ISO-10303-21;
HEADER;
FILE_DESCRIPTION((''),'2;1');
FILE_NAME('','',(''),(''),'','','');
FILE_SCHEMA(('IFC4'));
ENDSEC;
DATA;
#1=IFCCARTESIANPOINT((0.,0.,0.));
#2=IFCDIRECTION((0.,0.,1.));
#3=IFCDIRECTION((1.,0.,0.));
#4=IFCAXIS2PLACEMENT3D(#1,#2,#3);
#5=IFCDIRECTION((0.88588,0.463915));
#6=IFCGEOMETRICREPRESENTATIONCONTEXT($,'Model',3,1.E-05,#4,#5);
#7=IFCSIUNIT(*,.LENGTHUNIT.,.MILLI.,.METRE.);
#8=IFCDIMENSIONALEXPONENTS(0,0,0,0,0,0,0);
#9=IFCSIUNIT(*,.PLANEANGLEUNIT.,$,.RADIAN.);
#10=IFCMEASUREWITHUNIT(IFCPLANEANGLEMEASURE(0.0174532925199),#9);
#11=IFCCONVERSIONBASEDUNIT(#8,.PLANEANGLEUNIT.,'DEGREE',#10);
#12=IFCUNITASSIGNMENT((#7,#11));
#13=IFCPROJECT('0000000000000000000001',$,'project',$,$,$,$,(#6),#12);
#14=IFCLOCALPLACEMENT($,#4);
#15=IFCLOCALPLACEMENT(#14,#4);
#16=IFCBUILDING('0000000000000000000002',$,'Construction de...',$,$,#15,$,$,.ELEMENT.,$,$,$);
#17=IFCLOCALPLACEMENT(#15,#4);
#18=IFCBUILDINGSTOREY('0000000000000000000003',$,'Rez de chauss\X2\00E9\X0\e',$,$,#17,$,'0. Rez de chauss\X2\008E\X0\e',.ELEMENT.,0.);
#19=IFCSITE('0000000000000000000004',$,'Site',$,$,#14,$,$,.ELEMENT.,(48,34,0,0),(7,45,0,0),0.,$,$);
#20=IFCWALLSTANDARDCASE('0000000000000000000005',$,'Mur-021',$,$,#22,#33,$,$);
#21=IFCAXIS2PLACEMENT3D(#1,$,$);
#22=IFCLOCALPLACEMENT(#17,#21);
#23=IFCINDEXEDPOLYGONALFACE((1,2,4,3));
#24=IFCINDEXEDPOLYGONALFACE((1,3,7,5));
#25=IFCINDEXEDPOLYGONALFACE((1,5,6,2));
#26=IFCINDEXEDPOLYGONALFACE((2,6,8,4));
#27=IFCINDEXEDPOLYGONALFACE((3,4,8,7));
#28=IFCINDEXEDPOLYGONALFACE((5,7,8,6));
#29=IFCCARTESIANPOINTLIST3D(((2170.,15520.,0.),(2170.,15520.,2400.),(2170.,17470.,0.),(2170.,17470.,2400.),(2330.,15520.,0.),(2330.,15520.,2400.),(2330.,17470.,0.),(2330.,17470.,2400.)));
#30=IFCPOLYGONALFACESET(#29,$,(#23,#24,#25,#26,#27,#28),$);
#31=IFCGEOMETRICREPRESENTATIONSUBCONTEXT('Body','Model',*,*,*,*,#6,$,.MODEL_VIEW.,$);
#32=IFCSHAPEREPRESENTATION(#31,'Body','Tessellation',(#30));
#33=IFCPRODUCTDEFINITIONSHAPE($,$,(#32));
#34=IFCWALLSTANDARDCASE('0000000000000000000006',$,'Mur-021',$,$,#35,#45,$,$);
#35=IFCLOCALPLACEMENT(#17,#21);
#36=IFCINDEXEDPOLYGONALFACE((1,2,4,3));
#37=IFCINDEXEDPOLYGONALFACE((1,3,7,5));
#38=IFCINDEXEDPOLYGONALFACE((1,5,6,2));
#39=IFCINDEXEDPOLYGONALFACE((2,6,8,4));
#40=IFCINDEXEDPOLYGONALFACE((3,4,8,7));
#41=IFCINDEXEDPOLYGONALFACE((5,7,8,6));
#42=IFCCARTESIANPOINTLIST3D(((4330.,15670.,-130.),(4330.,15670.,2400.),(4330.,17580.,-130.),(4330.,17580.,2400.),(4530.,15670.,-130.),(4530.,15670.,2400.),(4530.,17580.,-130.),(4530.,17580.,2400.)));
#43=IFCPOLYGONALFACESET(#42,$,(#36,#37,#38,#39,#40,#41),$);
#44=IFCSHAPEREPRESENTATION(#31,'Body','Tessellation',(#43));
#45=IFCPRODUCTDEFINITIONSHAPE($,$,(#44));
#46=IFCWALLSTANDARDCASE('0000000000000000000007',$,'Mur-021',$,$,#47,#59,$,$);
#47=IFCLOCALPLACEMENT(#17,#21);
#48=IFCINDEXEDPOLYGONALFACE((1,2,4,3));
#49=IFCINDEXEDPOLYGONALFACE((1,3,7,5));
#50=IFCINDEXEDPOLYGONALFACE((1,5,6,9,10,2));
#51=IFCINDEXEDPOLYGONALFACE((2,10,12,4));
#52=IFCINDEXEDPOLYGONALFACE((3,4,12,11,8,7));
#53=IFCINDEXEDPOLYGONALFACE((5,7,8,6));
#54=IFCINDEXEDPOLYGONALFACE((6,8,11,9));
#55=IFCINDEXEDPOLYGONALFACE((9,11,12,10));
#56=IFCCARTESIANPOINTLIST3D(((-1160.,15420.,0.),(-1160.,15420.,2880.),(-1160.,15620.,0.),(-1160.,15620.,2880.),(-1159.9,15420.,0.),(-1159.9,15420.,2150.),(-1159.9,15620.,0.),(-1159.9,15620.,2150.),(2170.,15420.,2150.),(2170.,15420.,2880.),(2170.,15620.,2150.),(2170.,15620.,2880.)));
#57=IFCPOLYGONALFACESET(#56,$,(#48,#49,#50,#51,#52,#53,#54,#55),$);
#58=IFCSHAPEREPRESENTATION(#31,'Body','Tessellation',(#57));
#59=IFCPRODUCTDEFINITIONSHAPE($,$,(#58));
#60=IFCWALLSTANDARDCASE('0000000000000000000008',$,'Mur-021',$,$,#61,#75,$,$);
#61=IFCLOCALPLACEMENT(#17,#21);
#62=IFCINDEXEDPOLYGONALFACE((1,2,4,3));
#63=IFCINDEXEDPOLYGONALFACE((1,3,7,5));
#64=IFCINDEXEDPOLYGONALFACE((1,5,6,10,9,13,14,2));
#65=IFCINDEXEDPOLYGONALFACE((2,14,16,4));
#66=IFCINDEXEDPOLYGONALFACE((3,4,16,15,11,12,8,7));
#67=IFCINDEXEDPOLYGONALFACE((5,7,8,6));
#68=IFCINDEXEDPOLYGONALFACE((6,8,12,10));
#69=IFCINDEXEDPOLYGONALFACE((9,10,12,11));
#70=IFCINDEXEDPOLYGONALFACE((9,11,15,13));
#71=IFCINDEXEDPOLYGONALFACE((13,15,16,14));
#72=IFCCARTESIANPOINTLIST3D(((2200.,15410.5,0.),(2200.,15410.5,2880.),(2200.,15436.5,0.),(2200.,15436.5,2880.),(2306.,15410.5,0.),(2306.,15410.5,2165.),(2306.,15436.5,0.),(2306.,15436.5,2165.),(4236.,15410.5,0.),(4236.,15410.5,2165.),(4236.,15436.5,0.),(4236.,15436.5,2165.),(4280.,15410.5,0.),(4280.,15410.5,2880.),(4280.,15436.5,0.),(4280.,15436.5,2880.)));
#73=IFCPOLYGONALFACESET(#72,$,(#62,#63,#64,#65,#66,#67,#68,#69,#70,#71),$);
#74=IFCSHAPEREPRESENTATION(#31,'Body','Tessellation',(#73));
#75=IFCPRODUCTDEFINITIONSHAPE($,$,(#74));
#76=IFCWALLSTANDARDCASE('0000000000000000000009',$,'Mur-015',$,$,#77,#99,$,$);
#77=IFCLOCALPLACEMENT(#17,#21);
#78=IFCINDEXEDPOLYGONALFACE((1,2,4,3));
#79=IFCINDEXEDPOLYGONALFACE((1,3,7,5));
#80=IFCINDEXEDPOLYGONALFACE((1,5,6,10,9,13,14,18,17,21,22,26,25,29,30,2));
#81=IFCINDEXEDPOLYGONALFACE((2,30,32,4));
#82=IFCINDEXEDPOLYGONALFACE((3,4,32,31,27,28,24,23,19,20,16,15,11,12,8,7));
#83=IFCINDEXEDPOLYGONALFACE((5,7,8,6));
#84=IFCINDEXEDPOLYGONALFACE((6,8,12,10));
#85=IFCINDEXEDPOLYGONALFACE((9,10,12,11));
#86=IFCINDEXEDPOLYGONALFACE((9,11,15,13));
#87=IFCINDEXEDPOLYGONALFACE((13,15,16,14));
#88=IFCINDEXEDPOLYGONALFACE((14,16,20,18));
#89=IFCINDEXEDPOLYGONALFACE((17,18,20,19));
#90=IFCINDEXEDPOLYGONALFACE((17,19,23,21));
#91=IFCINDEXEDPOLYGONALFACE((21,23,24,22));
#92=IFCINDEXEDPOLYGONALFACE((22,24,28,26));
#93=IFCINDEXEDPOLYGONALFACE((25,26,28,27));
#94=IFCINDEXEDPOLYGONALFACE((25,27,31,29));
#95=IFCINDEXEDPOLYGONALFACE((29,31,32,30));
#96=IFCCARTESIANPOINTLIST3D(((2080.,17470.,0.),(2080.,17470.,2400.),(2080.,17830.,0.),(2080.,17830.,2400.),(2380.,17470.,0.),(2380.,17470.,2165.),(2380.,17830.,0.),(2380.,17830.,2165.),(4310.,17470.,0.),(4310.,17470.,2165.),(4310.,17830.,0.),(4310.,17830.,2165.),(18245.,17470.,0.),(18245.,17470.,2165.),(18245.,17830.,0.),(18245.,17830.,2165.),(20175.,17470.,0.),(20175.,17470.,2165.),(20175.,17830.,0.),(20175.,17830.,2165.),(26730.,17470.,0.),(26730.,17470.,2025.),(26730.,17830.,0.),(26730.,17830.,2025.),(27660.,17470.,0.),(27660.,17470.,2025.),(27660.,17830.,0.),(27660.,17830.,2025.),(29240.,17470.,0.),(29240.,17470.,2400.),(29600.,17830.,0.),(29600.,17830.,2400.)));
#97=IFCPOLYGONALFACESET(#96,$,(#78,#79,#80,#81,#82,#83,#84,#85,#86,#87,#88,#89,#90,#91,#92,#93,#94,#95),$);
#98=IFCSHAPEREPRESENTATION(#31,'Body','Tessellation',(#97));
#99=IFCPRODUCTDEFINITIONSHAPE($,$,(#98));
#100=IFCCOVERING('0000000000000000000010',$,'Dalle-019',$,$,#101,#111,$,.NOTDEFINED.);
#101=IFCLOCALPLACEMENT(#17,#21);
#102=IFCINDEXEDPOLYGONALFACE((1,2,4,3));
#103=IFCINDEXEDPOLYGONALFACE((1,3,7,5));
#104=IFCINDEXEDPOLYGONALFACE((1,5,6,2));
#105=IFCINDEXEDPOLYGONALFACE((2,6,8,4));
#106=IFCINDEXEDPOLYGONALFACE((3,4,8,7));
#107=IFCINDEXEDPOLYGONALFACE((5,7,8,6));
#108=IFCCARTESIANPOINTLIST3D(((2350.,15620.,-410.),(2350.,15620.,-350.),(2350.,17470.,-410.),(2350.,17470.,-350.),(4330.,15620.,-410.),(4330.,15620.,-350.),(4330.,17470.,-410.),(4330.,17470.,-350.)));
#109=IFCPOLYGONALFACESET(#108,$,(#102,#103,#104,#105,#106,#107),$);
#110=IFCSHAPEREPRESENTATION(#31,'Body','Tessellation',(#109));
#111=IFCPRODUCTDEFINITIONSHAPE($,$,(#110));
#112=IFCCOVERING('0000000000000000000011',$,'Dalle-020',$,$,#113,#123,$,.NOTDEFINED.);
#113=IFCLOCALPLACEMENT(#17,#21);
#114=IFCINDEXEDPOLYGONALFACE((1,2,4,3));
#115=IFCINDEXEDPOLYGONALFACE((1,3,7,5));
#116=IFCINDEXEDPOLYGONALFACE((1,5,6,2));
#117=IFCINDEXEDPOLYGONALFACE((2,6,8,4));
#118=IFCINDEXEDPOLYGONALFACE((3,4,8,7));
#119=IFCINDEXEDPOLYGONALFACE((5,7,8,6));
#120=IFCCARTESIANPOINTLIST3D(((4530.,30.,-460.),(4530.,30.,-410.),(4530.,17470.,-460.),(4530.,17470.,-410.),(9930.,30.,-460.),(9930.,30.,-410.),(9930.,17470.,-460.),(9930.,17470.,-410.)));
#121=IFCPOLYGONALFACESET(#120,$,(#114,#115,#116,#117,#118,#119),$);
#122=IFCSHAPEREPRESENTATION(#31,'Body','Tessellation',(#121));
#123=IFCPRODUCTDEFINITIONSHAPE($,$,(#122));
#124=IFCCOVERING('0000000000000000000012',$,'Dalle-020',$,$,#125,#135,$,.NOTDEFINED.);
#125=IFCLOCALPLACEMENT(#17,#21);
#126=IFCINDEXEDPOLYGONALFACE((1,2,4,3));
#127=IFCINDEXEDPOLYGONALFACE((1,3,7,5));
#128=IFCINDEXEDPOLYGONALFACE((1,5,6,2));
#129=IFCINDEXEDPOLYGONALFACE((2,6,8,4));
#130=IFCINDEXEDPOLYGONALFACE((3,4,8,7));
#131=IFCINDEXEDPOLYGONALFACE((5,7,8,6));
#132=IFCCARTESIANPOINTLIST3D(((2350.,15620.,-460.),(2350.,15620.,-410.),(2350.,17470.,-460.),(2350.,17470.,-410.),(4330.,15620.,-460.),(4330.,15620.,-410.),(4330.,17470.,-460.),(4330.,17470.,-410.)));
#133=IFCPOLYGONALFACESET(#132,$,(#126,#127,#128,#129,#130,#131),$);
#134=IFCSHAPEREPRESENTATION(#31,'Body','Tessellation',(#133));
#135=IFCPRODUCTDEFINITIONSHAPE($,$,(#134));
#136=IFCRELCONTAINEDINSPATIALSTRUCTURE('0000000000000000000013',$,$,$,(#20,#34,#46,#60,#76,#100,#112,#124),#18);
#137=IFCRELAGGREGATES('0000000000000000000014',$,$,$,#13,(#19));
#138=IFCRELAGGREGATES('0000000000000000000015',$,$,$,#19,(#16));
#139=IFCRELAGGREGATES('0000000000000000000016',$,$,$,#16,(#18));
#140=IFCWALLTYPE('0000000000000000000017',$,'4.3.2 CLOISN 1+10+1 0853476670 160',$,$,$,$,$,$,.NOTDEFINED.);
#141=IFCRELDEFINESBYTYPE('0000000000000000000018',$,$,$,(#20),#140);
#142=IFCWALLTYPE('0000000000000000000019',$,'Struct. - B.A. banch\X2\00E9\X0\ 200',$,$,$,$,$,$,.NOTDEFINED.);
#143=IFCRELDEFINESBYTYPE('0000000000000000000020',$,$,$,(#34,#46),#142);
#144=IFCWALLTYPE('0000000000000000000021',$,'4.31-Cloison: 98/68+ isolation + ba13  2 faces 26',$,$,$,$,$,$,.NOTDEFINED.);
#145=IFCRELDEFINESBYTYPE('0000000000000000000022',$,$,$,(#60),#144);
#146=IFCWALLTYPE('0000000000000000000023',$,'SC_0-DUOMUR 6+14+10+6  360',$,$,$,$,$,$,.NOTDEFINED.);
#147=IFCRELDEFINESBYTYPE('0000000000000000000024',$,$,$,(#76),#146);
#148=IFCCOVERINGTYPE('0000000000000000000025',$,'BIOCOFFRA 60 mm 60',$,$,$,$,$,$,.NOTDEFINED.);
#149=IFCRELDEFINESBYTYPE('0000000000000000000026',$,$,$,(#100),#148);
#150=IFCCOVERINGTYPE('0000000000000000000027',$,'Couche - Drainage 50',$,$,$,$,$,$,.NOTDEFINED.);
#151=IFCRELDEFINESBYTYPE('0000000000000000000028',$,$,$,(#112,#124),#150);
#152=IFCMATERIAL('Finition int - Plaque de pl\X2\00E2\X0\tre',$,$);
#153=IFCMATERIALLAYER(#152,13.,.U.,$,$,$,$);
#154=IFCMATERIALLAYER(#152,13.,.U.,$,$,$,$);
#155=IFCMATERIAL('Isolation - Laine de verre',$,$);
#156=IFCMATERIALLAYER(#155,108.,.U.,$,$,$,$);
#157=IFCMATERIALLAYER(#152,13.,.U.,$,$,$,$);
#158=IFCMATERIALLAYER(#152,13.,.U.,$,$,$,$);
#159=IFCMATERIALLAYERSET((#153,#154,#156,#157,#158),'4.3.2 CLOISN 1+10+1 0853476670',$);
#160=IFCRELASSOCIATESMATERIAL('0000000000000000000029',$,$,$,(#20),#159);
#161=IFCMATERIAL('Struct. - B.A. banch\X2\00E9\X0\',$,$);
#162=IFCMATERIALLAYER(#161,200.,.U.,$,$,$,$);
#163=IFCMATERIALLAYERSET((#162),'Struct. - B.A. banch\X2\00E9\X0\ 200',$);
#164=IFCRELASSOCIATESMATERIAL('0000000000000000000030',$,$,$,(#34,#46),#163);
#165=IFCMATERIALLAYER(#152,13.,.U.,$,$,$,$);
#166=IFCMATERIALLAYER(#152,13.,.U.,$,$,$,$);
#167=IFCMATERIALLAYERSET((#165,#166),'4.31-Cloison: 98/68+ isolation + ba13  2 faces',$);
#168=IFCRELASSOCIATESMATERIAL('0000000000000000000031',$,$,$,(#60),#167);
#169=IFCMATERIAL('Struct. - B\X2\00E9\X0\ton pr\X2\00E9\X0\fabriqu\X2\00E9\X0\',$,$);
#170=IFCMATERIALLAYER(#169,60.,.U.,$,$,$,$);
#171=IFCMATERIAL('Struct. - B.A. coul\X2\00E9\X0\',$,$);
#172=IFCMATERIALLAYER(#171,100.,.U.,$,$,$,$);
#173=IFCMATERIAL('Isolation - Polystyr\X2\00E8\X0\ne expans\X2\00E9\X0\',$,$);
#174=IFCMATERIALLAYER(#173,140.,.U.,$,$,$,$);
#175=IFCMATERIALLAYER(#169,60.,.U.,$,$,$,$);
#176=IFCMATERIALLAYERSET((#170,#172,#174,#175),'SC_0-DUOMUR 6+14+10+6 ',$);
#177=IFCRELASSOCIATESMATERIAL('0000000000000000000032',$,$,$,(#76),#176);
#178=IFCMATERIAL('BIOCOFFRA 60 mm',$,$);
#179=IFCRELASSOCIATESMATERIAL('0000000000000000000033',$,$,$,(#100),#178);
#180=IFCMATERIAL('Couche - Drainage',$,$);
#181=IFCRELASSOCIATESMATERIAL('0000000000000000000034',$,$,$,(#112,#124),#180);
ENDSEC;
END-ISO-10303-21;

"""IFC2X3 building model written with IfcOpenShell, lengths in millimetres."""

from ifc_helpers import new_model, entity, si_unit, converted_unit, direction, frame, origin_with_axes, origin_2d_with_axis, place, context, subcontext, project, spatial, polyline, rectangle, outline, extrude, material, layer, layer_set, layer_usage, type_object, element, save


model = new_model("IFC2X3")

# Units and contexts
model_context = context("Model", 3, precision=1e-05, world=origin_with_axes(), true_north=direction((0.88588, 0.463915)))
body_context = subcontext(model_context, "Body", "Model", "MODEL_VIEW")
ifc_project = project(units=[si_unit("LENGTHUNIT", "METRE", prefix="MILLI"), converted_unit("PLANEANGLEUNIT", "DEGREE", entity("IfcPlaneAngleMeasure", 0.0174532925199), si_unit("PLANEANGLEUNIT", "RADIAN"), dimensions=[0, 0, 0, 0, 0, 0, 0])], contexts=[model_context])

# Site, building, storey
site_placement = place(None, origin_with_axes())
site = spatial("IfcSite", under=ifc_project, at=site_placement, Name="Site", CompositionType="ELEMENT", RefLatitude=(48, 34, 0, 0), RefLongitude=(7, 45, 0, 0), RefElevation=0.0)
building_placement = place(site_placement, origin_with_axes())
building = spatial("IfcBuilding", under=site, at=building_placement, Name="Construction de...", CompositionType="ELEMENT")
storey_placement = place(building_placement, origin_with_axes())
storey = spatial("IfcBuildingStorey", under=building, at=storey_placement, Name="Rez de chaussée", LongName="0. Rez de chauss\u008ee", CompositionType="ELEMENT", Elevation=0.0)

# Shared definitions
ifc_material_1 = material(Name="Struct. - B.A. coulé")

# Shared definitions
ifc_material_2 = material(Name="Finition int - Plaque de plâtre")
ifc_layer_1 = layer(ifc_material_2, 13.0, ventilated="UNKNOWN")
ifc_layer_2 = layer(ifc_material_2, 13.0, ventilated="UNKNOWN")
ifc_material_3 = material(Name="Isolation - Laine de verre")
ifc_layer_3 = layer(ifc_material_3, 108.0, ventilated="UNKNOWN")
ifc_layer_4 = layer(ifc_material_2, 13.0, ventilated="UNKNOWN")
ifc_layer_5 = layer(ifc_material_2, 13.0, ventilated="UNKNOWN")
ifc_layer_set_1 = layer_set([ifc_layer_1, ifc_layer_2, ifc_layer_3, ifc_layer_4, ifc_layer_5], Name="4.3.2 CLOISN 1+10+1 0853476670")
wall_type_1 = type_object("IfcWallType", Name="4.3.2 CLOISN 1+10+1 0853476670 160", PredefinedType="NOTDEFINED")

# Walls
ifc_layer_usage_1 = layer_usage(ifc_layer_set_1, "AXIS2", "NEGATIVE", 80.0)
wall_1_placement = place(storey_placement, frame((2250.0, 15520.0, 0.0), z_axis=(0.0, 0.0, 1.0), x_axis=(0.0, 1.0, 0.0)))
element("IfcWallStandardCase", 1, at=wall_1_placement, inside=storey, type_object=wall_type_1, material=ifc_layer_usage_1, Name="Mur-021", context=body_context, shape_type="SweptSolid", body=[
    extrude(outline(polyline([(0.0, -80.0), (1950.0, -80.0), (1950.0, 80.0), (0.0, 80.0), (0.0, -80.0)])), origin_with_axes(), (0.0, 0.0, 1.0), 2400.0),
])
ifc_material_4 = material(Name="Struct. - B.A. banché")
ifc_layer_6 = layer(ifc_material_4, 200.0, ventilated="UNKNOWN")
ifc_layer_set_2 = layer_set([ifc_layer_6], Name="Struct. - B.A. banché 200")
ifc_layer_usage_2 = layer_usage(ifc_layer_set_2, "AXIS2", "NEGATIVE", 100.0)
wall_type_2 = type_object("IfcWallType", Name="Struct. - B.A. banché 200", PredefinedType="NOTDEFINED")
wall_2_placement = place(storey_placement, frame((4430.0, 15670.0, -130.0), z_axis=(0.0, 0.0, 1.0), x_axis=(0.0, 1.0, 0.0)))
element("IfcWallStandardCase", 2, at=wall_2_placement, inside=storey, type_object=wall_type_2, material=ifc_layer_usage_2, Name="Mur-021", context=body_context, shape_type="SweptSolid", body=[
    extrude(outline(polyline([(0.0, -100.0), (1910.0, -100.0), (1910.0, 100.0), (0.0, 100.0), (0.0, -100.0)])), origin_with_axes(), (0.0, 0.0, 1.0), 2530.0),
])

# Walls, openings
ifc_layer_usage_3 = layer_usage(ifc_layer_set_2, "AXIS2", "NEGATIVE", 100.0)
wall_3_placement = place(storey_placement, frame((-1160.0, 15520.0, 0.0), z_axis=(0.0, 0.0, 1.0), x_axis=(1.0, 0.0, 0.0)))
wall_3 = element("IfcWallStandardCase", 3, at=wall_3_placement, inside=storey, type_object=wall_type_2, material=ifc_layer_usage_3, Name="Mur-021", context=body_context, shape_type="SweptSolid", body=[
    extrude(outline(polyline([(0.0, -100.0), (3330.0, -100.0), (3330.0, 100.0), (0.0, 100.0), (0.0, -100.0)])), origin_with_axes(), (0.0, 0.0, 1.0), 2880.0),
])
opening_1_placement = place(wall_3_placement, frame((1665.1, 0.0, 0.0), z_axis=(0.0, 0.0, 1.0), x_axis=(1.0, 0.0, 0.0)))
element("IfcOpeningElement", 4, at=opening_1_placement, cuts=wall_3, context=body_context, shape_type="SweptSolid", body=[
    extrude(rectangle(XDim=3329.9, YDim=2150.0, at=origin_2d_with_axis()), frame((0.0, -100.0, 1075.0), z_axis=(0.0, 1.0, 0.0), x_axis=(1.0, 0.0, 0.0)), (0.0, 0.0, -1.0), 200.0),
    extrude(rectangle(XDim=3329.9, YDim=2150.0, at=origin_2d_with_axis()), frame((0.0, -100.0, 1075.0), z_axis=(0.0, -1.0, 0.0), x_axis=(1.0, 0.0, 0.0)), (0.0, 0.0, -1.0), 200.0),
])
ifc_layer_7 = layer(ifc_material_2, 13.0, ventilated="UNKNOWN")
ifc_layer_8 = layer(ifc_material_2, 13.0, ventilated="UNKNOWN")
ifc_layer_set_3 = layer_set([ifc_layer_7, ifc_layer_8], Name="4.31-Cloison: 98/68+ isolation + ba13  2 faces")
ifc_layer_usage_4 = layer_usage(ifc_layer_set_3, "AXIS2", "NEGATIVE", 13.0)
wall_type_3 = type_object("IfcWallType", Name="4.31-Cloison: 98/68+ isolation + ba13  2 faces 26", PredefinedType="NOTDEFINED")
wall_4_placement = place(storey_placement, frame((2200.0, 15423.5, 0.0), z_axis=(0.0, 0.0, 1.0), x_axis=(1.0, 0.0, 0.0)))
wall_4 = element("IfcWallStandardCase", 5, at=wall_4_placement, inside=storey, type_object=wall_type_3, material=ifc_layer_usage_4, Name="Mur-021", context=body_context, shape_type="SweptSolid", body=[
    extrude(outline(polyline([(0.0, -13.0), (2080.0, -13.0), (2080.0, 13.0), (0.0, 13.0), (0.0, -13.0)])), origin_with_axes(), (0.0, 0.0, 1.0), 2880.0),
])
opening_2_placement = place(wall_4_placement, frame((1071.0, 0.0, 0.0), z_axis=(0.0, 0.0, 1.0), x_axis=(1.0, 0.0, 0.0)))
element("IfcOpeningElement", 6, at=opening_2_placement, cuts=wall_4, context=body_context, shape_type="SweptSolid", body=[
    extrude(rectangle(XDim=1930.0, YDim=2165.0, at=origin_2d_with_axis()), frame((0.0, -26.0, 1082.5), z_axis=(0.0, 1.0, 0.0), x_axis=(1.0, 0.0, 0.0)), (0.0, 0.0, 1.0), 128.0),
])

# Wall, openings
ifc_material_5 = material(Name="Struct. - Béton préfabriqué")
ifc_layer_9 = layer(ifc_material_5, 60.0, ventilated="UNKNOWN")
ifc_layer_10 = layer(ifc_material_1, 100.0, ventilated="UNKNOWN")
ifc_material_6 = material(Name="Isolation - Polystyrène expansé")
ifc_layer_11 = layer(ifc_material_6, 140.0, ventilated="UNKNOWN")
ifc_layer_12 = layer(ifc_material_5, 60.0, ventilated="UNKNOWN")
ifc_layer_set_4 = layer_set([ifc_layer_9, ifc_layer_10, ifc_layer_11, ifc_layer_12], Name="SC_0-DUOMUR 6+14+10+6 ")
ifc_layer_usage_5 = layer_usage(ifc_layer_set_4, "AXIS2", "POSITIVE", -180.0)
wall_type_4 = type_object("IfcWallType", Name="SC_0-DUOMUR 6+14+10+6  360", PredefinedType="NOTDEFINED")
wall_5_placement = place(storey_placement, frame((2080.0, 17650.0, 0.0), z_axis=(0.0, 0.0, 1.0), x_axis=(1.0, 0.0, 0.0)))
wall_5 = element("IfcWallStandardCase", 7, at=wall_5_placement, inside=storey, type_object=wall_type_4, material=ifc_layer_usage_5, Name="Mur-015", context=body_context, shape_type="SweptSolid", body=[
    extrude(outline(polyline([(0.0, -180.0), (27160.0, -180.0), (27520.0, 180.0), (0.0, 180.0), (0.0, -180.0)])), origin_with_axes(), (0.0, 0.0, 1.0), 2400.0),
])
opening_3_placement = place(wall_5_placement, frame((1265.0, 0.0, 0.0), z_axis=(0.0, 0.0, 1.0), x_axis=(1.0, 0.0, 0.0)))
element("IfcOpeningElement", 8, at=opening_3_placement, cuts=wall_5, context=body_context, shape_type="SweptSolid", body=[
    extrude(rectangle(XDim=1930.0, YDim=2165.0, at=origin_2d_with_axis()), frame((0.0, -360.0, 1082.5), z_axis=(0.0, -1.0, 0.0), x_axis=(-1.0, 0.0, 0.0)), (0.0, 0.0, -1.0), 1080.0),
])
opening_4_placement = place(wall_5_placement, frame((25115.0, 0.0, 0.0), z_axis=(0.0, 0.0, 1.0), x_axis=(1.0, 0.0, 0.0)))
element("IfcOpeningElement", 9, at=opening_4_placement, cuts=wall_5, context=body_context, shape_type="SweptSolid", body=[
    extrude(rectangle(XDim=930.0, YDim=2025.0, at=origin_2d_with_axis()), frame((0.0, -360.0, 1012.5), z_axis=(0.0, 1.0, 0.0), x_axis=(1.0, 0.0, 0.0)), (0.0, 0.0, 1.0), 1080.0),
])
opening_5_placement = place(wall_5_placement, frame((17130.0, 0.0, 0.0), z_axis=(0.0, 0.0, 1.0), x_axis=(1.0, 0.0, 0.0)))
element("IfcOpeningElement", 10, at=opening_5_placement, cuts=wall_5, context=body_context, shape_type="SweptSolid", body=[
    extrude(rectangle(XDim=1930.0, YDim=2165.0, at=origin_2d_with_axis()), frame((0.0, -360.0, 1082.5), z_axis=(0.0, 1.0, 0.0), x_axis=(1.0, 0.0, 0.0)), (0.0, 0.0, 1.0), 1080.0),
])

# Coverings
ifc_material_7 = material(Name="BIOCOFFRA 60 mm")
covering_type_1 = type_object("IfcCoveringType", Name="BIOCOFFRA 60 mm 60", PredefinedType="NOTDEFINED")
covering_1_placement = place(storey_placement, frame((2350.0, 15620.0, -350.0), z_axis=(0.0, 0.0, 1.0), x_axis=(1.0, 0.0, 0.0)))
element("IfcCovering", 11, at=covering_1_placement, inside=storey, type_object=covering_type_1, material=ifc_material_7, Name="Dalle-019", PredefinedType="NOTDEFINED", context=body_context, shape_type="SweptSolid", body=[
    extrude(outline(polyline([(0.0, 0.0), (1980.0, 0.0), (1980.0, 1850.0), (0.0, 1850.0), (0.0, 0.0)])), frame((0.0, 0.0, -60.0), z_axis=(0.0, 0.0, 1.0), x_axis=(1.0, 0.0, 0.0)), (0.0, 0.0, 1.0), 60.0),
])
ifc_material_8 = material(Name="Couche - Drainage")
covering_type_2 = type_object("IfcCoveringType", Name="Couche - Drainage 50", PredefinedType="NOTDEFINED")
covering_2_placement = place(storey_placement, frame((4530.0, 30.0, -410.0), z_axis=(0.0, 0.0, 1.0), x_axis=(1.0, 0.0, 0.0)))
element("IfcCovering", 12, at=covering_2_placement, inside=storey, type_object=covering_type_2, material=ifc_material_8, Name="Dalle-020", PredefinedType="NOTDEFINED", context=body_context, shape_type="SweptSolid", body=[
    extrude(outline(polyline([(0.0, 0.0), (5400.0, 0.0), (5400.0, 17440.0), (0.0, 17440.0), (0.0, 0.0)])), frame((0.0, 0.0, -50.0), z_axis=(0.0, 0.0, 1.0), x_axis=(1.0, 0.0, 0.0)), (0.0, 0.0, 1.0), 50.0),
])
covering_3_placement = place(storey_placement, frame((2350.0, 15620.0, -410.0), z_axis=(0.0, 0.0, 1.0), x_axis=(1.0, 0.0, 0.0)))
element("IfcCovering", 13, at=covering_3_placement, inside=storey, type_object=covering_type_2, material=ifc_material_8, Name="Dalle-020", PredefinedType="NOTDEFINED", context=body_context, shape_type="SweptSolid", body=[
    extrude(outline(polyline([(0.0, 0.0), (1980.0, 0.0), (1980.0, 1850.0), (0.0, 1850.0), (0.0, 0.0)])), frame((0.0, 0.0, -50.0), z_axis=(0.0, 0.0, 1.0), x_axis=(1.0, 0.0, 0.0)), (0.0, 0.0, 1.0), 50.0),
])

save(model, "model.ifc")
